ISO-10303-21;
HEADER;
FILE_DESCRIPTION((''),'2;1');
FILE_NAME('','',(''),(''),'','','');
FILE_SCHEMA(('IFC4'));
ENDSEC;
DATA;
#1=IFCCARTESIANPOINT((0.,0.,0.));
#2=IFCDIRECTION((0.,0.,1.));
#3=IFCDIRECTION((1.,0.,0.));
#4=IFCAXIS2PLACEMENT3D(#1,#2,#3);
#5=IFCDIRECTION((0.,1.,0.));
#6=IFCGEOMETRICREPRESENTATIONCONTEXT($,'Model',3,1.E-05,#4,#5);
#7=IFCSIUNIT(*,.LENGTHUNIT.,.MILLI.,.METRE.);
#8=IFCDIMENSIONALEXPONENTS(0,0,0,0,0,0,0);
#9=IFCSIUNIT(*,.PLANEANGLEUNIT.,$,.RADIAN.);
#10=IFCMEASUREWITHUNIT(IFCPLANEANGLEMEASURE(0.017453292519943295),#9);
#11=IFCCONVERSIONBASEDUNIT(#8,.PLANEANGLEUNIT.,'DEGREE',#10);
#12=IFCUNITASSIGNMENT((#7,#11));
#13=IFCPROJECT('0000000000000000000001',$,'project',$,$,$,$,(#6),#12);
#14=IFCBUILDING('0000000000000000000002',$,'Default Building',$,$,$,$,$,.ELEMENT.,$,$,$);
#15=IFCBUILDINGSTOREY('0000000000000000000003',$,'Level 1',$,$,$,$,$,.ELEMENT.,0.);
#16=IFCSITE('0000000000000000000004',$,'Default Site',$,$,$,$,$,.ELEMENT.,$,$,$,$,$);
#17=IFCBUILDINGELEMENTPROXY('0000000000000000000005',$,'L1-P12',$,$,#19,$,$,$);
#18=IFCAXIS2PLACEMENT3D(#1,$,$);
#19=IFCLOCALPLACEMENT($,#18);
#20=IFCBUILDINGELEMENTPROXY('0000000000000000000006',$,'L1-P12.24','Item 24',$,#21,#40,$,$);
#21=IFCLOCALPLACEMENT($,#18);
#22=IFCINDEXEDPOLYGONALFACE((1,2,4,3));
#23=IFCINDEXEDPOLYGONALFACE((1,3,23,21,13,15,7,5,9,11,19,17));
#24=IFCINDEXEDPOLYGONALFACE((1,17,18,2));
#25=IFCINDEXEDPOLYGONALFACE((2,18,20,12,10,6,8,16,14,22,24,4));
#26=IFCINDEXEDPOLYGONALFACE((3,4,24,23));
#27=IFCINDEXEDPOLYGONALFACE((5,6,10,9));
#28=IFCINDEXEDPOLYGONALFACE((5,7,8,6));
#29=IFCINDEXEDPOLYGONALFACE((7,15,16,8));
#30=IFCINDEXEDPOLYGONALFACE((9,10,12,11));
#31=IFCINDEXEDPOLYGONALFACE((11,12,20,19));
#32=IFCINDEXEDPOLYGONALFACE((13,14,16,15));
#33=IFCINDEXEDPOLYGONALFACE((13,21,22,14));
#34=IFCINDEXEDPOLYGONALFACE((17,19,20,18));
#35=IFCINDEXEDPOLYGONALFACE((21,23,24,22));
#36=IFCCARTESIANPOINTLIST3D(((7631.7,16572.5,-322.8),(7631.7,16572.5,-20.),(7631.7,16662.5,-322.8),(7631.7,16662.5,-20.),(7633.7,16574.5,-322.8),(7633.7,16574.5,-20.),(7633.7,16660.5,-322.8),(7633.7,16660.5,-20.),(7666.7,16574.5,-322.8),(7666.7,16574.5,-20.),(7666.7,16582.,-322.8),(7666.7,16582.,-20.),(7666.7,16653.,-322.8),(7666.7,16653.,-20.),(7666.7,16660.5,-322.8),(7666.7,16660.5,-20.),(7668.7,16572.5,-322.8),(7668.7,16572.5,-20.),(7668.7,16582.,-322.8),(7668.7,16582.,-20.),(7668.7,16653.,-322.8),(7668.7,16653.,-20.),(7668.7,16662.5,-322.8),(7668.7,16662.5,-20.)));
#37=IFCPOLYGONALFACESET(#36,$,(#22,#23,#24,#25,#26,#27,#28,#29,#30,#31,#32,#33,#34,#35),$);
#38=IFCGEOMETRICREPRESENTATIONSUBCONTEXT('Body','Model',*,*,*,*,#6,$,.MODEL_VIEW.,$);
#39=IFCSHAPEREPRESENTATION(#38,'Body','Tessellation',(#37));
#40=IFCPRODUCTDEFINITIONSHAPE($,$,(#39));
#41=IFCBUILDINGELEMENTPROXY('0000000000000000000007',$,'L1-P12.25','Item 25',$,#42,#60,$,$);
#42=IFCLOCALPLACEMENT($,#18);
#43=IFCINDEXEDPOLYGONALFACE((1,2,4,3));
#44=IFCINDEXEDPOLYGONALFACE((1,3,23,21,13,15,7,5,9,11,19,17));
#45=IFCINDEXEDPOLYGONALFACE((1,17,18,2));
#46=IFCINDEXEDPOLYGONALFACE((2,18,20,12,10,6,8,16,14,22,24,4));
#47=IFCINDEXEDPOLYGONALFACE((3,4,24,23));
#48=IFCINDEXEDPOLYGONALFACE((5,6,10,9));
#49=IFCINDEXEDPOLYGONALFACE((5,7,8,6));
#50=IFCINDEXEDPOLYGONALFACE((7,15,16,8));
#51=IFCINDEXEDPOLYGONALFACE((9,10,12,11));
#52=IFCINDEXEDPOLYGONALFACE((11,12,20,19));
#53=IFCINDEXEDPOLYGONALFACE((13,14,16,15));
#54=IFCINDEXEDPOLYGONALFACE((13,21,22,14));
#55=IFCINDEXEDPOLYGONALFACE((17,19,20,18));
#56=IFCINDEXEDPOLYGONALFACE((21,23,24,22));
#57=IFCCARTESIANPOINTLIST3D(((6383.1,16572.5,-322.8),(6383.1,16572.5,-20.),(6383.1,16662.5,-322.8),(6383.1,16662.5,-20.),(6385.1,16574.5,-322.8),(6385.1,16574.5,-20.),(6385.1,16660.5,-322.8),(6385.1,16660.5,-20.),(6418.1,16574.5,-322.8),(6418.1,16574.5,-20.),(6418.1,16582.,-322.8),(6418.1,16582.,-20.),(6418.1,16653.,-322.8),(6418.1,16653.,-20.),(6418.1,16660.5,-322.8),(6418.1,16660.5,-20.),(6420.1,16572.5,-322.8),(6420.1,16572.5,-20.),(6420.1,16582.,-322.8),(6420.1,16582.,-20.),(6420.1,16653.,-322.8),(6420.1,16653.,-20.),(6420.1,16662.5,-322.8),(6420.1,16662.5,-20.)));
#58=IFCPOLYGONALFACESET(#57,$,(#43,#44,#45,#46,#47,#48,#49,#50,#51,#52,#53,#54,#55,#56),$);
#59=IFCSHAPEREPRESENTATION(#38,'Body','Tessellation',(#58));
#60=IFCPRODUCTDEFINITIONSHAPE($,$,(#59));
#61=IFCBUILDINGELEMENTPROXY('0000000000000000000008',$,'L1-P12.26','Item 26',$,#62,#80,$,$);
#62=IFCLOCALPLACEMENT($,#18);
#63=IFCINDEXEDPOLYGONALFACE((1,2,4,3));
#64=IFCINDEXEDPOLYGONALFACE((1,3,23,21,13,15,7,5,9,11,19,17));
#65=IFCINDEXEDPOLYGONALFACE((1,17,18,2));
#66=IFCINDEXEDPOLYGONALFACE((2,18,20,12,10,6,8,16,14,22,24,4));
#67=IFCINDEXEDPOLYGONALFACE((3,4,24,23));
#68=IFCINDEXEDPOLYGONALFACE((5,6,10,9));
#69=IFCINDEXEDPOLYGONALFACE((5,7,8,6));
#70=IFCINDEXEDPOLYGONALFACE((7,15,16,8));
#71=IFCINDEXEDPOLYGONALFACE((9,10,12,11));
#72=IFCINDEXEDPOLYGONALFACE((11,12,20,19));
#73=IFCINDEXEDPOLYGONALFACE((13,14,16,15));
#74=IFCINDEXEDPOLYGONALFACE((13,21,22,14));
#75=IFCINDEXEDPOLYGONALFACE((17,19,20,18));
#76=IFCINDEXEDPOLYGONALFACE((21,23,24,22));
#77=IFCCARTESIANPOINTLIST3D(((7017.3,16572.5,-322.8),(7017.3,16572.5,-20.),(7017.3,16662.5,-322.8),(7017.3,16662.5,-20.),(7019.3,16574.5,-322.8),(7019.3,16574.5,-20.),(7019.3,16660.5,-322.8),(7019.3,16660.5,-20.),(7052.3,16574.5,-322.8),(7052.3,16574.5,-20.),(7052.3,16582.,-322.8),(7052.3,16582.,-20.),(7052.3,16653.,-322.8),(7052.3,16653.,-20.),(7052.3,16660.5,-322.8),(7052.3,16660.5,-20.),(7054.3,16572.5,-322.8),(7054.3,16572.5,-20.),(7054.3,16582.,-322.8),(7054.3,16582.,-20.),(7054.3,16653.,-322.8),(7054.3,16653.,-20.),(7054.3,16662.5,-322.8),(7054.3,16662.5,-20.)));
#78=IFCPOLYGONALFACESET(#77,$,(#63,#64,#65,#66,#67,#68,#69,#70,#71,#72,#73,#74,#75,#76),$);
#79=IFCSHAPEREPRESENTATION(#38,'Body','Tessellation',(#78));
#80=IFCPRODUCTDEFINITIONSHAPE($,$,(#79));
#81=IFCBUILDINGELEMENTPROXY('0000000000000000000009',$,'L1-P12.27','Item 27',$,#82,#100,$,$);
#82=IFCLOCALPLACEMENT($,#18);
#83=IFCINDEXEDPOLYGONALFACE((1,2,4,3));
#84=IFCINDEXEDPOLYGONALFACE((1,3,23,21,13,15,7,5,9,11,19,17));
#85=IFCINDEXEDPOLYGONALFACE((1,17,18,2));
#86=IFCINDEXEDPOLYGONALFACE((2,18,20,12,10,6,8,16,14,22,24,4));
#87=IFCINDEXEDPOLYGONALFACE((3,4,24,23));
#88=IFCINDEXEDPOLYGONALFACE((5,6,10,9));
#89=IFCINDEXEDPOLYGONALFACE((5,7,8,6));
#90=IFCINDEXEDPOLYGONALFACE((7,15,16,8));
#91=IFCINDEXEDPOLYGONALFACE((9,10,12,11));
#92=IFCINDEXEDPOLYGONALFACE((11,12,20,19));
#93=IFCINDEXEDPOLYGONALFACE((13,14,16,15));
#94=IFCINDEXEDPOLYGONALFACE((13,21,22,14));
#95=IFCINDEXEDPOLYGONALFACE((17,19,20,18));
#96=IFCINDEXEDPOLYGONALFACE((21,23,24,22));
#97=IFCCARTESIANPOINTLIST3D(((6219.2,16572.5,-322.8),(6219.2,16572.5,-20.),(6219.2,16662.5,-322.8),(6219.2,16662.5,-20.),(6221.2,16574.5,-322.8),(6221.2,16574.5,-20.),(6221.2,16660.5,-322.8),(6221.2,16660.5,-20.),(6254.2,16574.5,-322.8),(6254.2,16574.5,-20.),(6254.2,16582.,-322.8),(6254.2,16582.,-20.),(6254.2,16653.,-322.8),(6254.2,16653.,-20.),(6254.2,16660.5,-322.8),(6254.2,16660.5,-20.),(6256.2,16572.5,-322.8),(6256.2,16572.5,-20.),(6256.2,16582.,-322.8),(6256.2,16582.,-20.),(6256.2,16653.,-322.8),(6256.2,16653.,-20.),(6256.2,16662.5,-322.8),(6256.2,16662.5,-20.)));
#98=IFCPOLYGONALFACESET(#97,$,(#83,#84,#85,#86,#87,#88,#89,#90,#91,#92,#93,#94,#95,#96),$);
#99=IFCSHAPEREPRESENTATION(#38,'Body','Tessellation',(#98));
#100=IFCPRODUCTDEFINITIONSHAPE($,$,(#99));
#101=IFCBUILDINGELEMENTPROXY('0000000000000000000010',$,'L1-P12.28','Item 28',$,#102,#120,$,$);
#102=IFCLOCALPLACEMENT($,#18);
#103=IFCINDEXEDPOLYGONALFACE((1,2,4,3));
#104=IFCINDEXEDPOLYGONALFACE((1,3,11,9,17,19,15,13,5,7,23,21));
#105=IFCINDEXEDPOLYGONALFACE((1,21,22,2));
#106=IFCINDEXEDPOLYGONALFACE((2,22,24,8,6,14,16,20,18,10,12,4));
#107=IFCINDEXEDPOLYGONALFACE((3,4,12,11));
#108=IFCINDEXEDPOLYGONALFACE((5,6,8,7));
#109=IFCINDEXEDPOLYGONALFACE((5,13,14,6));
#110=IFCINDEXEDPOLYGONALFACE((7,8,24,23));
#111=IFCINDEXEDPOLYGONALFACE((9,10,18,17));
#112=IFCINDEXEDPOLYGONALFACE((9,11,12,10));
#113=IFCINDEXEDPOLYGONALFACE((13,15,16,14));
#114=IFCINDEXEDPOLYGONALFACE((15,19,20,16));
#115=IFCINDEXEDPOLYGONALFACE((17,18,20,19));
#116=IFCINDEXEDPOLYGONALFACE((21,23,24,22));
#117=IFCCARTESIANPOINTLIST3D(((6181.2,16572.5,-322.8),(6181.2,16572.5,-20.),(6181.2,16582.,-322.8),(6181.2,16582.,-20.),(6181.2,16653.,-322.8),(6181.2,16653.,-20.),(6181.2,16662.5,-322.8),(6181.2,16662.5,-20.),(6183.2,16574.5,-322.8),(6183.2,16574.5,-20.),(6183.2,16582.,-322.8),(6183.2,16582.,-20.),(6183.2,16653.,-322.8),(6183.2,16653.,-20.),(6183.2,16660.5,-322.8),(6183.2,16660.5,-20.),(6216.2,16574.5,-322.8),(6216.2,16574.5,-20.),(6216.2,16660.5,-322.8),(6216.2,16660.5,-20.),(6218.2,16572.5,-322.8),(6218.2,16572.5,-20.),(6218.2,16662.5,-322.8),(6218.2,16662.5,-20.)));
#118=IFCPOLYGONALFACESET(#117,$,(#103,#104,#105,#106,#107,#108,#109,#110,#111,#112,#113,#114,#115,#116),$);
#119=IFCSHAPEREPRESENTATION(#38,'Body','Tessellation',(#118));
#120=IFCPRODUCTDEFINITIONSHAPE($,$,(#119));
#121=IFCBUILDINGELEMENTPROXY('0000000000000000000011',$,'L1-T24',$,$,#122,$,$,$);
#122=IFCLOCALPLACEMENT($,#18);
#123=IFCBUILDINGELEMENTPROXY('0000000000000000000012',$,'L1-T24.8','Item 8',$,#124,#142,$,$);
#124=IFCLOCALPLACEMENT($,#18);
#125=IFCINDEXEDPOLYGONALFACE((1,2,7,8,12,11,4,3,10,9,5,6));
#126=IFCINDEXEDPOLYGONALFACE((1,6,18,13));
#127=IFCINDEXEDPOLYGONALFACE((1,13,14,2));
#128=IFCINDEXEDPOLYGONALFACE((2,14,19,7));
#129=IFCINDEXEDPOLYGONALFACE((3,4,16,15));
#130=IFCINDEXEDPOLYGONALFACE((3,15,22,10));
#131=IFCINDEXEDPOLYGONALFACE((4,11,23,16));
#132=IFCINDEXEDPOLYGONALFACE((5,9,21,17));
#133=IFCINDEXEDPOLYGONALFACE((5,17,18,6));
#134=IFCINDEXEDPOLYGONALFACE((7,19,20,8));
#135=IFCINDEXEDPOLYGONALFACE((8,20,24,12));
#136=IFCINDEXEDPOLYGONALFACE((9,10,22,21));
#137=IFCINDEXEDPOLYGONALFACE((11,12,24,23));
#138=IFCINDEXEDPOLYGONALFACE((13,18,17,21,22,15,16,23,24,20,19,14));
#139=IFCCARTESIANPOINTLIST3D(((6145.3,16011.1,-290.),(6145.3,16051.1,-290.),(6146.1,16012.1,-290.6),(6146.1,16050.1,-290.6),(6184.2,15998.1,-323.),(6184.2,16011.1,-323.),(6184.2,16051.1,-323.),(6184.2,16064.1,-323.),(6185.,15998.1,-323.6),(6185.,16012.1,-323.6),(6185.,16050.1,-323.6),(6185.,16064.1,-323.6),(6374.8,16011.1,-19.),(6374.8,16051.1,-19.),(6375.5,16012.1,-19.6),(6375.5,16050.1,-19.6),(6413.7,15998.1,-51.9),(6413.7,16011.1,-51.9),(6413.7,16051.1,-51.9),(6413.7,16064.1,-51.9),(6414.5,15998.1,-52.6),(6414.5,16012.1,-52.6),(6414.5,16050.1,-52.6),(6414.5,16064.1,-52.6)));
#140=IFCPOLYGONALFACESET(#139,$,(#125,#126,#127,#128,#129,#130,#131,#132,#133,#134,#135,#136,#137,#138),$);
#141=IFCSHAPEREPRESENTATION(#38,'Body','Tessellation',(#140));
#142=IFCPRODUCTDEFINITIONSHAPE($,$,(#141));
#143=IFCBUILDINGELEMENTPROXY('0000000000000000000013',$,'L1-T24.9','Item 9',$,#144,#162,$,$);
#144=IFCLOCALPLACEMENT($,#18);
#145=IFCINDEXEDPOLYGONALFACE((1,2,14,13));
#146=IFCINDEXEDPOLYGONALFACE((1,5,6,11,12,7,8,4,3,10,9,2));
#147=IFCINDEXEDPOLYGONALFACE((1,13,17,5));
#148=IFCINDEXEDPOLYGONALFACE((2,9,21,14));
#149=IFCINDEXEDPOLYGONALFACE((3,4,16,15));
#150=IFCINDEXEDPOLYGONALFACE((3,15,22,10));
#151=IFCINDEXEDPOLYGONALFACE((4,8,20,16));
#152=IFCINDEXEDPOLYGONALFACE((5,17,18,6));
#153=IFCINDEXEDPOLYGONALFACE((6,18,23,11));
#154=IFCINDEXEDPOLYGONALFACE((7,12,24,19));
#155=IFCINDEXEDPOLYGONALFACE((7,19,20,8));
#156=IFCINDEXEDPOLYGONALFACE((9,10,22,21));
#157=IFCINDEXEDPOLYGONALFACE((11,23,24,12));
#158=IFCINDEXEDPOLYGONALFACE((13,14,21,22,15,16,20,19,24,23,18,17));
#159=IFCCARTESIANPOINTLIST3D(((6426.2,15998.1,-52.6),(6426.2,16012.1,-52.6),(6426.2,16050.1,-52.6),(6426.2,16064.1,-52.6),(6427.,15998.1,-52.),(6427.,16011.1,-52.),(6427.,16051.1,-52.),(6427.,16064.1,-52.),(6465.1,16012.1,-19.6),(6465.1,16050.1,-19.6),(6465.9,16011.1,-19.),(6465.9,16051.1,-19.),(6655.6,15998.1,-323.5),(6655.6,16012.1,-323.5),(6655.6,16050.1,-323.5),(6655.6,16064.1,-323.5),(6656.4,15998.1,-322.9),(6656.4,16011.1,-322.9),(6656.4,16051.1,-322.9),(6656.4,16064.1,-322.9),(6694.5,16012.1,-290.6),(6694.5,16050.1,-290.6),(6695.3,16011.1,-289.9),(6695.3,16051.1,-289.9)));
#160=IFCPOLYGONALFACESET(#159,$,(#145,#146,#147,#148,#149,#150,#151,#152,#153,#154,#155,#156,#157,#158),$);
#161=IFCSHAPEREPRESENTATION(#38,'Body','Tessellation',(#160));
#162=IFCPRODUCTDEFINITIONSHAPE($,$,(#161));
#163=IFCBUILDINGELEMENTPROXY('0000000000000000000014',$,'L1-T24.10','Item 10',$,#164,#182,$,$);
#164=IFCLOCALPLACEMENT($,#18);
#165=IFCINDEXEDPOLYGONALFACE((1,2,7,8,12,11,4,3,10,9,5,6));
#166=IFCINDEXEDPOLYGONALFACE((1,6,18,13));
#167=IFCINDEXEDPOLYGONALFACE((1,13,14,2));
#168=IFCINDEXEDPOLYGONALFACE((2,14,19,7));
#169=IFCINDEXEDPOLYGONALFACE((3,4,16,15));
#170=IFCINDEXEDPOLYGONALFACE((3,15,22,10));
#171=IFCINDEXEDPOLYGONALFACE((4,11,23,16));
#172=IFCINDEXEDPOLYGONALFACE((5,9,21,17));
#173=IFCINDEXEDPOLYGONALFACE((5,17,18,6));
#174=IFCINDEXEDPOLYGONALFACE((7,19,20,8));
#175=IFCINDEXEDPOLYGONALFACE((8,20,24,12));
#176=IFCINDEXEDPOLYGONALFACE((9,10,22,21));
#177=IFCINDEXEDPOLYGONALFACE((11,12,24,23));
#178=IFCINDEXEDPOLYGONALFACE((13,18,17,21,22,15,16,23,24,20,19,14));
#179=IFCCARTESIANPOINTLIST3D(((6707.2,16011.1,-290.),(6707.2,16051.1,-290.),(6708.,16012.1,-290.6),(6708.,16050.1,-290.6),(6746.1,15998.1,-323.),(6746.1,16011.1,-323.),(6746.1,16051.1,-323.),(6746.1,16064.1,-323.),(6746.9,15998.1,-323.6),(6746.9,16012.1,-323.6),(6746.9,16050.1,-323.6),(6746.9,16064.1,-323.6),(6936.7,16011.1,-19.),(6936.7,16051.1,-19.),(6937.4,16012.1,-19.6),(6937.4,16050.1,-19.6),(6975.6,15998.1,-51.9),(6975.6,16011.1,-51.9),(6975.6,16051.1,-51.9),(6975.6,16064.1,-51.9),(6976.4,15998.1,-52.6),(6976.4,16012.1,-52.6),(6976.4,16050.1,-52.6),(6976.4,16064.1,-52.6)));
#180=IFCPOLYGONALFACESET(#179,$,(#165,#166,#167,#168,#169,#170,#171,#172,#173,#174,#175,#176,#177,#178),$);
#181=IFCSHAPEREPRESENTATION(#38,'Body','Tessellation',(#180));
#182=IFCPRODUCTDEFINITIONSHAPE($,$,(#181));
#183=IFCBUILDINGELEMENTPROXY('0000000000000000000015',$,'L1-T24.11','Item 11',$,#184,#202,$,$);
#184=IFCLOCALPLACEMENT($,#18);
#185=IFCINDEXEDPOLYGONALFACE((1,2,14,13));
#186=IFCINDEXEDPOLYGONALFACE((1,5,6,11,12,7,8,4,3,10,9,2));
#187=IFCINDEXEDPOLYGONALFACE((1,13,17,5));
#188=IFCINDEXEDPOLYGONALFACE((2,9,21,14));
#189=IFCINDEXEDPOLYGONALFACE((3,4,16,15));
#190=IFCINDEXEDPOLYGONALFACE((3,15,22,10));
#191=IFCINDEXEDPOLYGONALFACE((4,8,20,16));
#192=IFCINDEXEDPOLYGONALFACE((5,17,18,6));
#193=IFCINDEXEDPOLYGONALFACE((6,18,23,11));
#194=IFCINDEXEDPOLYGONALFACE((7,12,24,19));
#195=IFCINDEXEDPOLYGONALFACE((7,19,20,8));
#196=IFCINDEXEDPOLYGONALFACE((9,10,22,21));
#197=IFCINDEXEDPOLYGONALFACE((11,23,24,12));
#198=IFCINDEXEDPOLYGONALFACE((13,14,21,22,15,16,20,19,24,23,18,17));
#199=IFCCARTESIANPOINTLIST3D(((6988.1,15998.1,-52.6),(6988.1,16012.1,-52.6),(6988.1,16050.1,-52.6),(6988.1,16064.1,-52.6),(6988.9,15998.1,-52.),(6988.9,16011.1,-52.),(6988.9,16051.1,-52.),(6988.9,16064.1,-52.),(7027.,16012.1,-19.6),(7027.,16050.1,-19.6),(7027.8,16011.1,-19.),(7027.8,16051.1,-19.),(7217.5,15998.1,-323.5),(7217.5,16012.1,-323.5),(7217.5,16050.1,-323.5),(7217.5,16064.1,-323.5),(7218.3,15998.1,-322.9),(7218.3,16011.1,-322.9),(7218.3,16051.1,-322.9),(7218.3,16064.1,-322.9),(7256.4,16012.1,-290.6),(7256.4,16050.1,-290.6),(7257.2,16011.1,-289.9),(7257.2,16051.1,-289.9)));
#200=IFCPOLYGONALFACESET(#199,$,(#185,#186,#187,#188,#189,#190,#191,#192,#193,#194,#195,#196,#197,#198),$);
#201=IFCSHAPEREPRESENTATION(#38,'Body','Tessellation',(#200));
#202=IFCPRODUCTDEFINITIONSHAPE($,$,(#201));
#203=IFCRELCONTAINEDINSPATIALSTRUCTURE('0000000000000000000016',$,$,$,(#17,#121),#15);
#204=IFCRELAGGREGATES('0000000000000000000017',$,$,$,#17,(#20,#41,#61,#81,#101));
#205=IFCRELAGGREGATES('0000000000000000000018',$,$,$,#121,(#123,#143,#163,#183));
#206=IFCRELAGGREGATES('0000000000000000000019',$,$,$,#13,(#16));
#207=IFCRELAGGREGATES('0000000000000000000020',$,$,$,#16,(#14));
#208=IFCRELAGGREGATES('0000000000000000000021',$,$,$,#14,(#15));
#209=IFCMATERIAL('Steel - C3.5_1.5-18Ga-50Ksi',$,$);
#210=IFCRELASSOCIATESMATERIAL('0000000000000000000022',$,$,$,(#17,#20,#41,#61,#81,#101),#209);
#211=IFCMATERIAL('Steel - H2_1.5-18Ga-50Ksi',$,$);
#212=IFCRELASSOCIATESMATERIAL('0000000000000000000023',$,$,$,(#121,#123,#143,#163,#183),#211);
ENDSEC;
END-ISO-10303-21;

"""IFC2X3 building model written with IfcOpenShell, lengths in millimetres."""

from ifc_helpers import new_model, entity, si_unit, converted_unit, direction, frame, origin, origin_with_axes, origin_2d_with_axis, place, context, subcontext, project, spatial, polyline, c_section, outline, extrude, material, element, aggregate, save


model = new_model("IFC2X3")

# Units and contexts
model_context = context("Model", 3, precision=1e-05, world=origin_with_axes(), true_north=direction((0.0, 1.0, 0.0)))
body_context = subcontext(model_context, "Body", "Model", "MODEL_VIEW")
ifc_project = project(units=[si_unit("LENGTHUNIT", "METRE", prefix="MILLI"), converted_unit("PLANEANGLEUNIT", "DEGREE", entity("IfcPlaneAngleMeasure", 0.017453292519943295), si_unit("PLANEANGLEUNIT", "RADIAN"), dimensions=[0, 0, 0, 0, 0, 0, 0])], contexts=[model_context])

# Site, building, storey
site = spatial("IfcSite", under=ifc_project, Name="Default Site", CompositionType="ELEMENT")
building = spatial("IfcBuilding", under=site, Name="Default Building", CompositionType="ELEMENT")
storey = spatial("IfcBuildingStorey", under=building, Name="Level 1", CompositionType="ELEMENT", Elevation=0.0)

# Building element proxies
ifc_material_1 = material(Name="Steel - C3.5_1.5-18Ga-50Ksi")
proxy_1 = element("IfcBuildingElementProxy", 1, inside=storey, material=ifc_material_1, Name="L1-P12")
proxy_2_placement = place(None, frame((7650.2, 16617.5, -322.8), z_axis=(0.0, 0.0, 1.0), x_axis=(37.0, 0.0, 0.0)))
proxy_2 = element("IfcBuildingElementProxy", 2, at=proxy_2_placement, material=ifc_material_1, Name="L1-P12.24", Description="Item 24", context=body_context, shape_type="SweptSolid", body=[
    extrude(c_section(Depth=90.0, Width=37.0, WallThickness=2.0, Girth=9.5, at=origin_2d_with_axis()), origin(), (0.0, 0.0, 1.0), 302.8),
])
proxy_3_placement = place(None, frame((6401.6, 16617.5, -322.8), z_axis=(0.0, 0.0, 1.0), x_axis=(37.0, 0.0, 0.0)))
proxy_3 = element("IfcBuildingElementProxy", 3, at=proxy_3_placement, material=ifc_material_1, Name="L1-P12.25", Description="Item 25", context=body_context, shape_type="SweptSolid", body=[
    extrude(c_section(Depth=90.0, Width=37.0, WallThickness=2.0, Girth=9.5, at=origin_2d_with_axis()), origin(), (0.0, 0.0, 1.0), 302.8),
])
proxy_4_placement = place(None, frame((7035.8, 16617.5, -322.8), z_axis=(0.0, 0.0, 1.0), x_axis=(37.0, 0.0, 0.0)))
proxy_4 = element("IfcBuildingElementProxy", 4, at=proxy_4_placement, material=ifc_material_1, Name="L1-P12.26", Description="Item 26", context=body_context, shape_type="SweptSolid", body=[
    extrude(c_section(Depth=90.0, Width=37.0, WallThickness=2.0, Girth=9.5, at=origin_2d_with_axis()), origin(), (0.0, 0.0, 1.0), 302.8),
])
proxy_5_placement = place(None, frame((6237.7, 16617.5, -322.8), z_axis=(0.0, 0.0, 1.0), x_axis=(37.0, 0.0, 0.0)))
proxy_5 = element("IfcBuildingElementProxy", 5, at=proxy_5_placement, material=ifc_material_1, Name="L1-P12.27", Description="Item 27", context=body_context, shape_type="SweptSolid", body=[
    extrude(c_section(Depth=90.0, Width=37.0, WallThickness=2.0, Girth=9.5, at=origin_2d_with_axis()), origin(), (0.0, 0.0, 1.0), 302.8),
])
proxy_6_placement = place(None, frame((6199.7, 16617.5, -20.0), z_axis=(0.0, 0.0, -1.0), x_axis=(-37.0, 0.0, 0.0)))
proxy_6 = element("IfcBuildingElementProxy", 6, at=proxy_6_placement, material=ifc_material_1, Name="L1-P12.28", Description="Item 28", context=body_context, shape_type="SweptSolid", body=[
    extrude(c_section(Depth=90.0, Width=37.0, WallThickness=2.0, Girth=9.5, at=origin_2d_with_axis()), origin(), (0.0, 0.0, 1.0), 302.8),
])
aggregate(proxy_1, [proxy_2, proxy_3, proxy_4, proxy_5, proxy_6])
ifc_material_2 = material(Name="Steel - H2_1.5-18Ga-50Ksi")
proxy_7 = element("IfcBuildingElementProxy", 7, inside=storey, material=ifc_material_2, Name="L1-T24")
proxy_8_placement = place(None, frame((6185.0, 15998.1, -323.6), z_axis=(0.646, 0.0, 0.763), x_axis=(0.0, 40.0, 0.0)))
proxy_8 = element("IfcBuildingElementProxy", 8, at=proxy_8_placement, material=ifc_material_2, Name="L1-T24.8", Description="Item 8", context=body_context, shape_type="SweptSolid", body=[
    extrude(outline(polyline([(0.0, 0.0), (14.0, 0.0), (14.0, 51.0), (52.0, 51.0), (52.0, 0.0), (66.0, 0.0), (66.0, 1.0), (53.0, 1.0), (53.0, 52.0), (13.0, 52.0), (13.0, 1.0), (0.0, 1.0), (0.0, 0.0)])), origin(), (0.0, 0.0, 1.0), 355.1),
])
proxy_9_placement = place(None, frame((6426.2, 15998.1, -52.6), z_axis=(0.646, 0.0, -0.763), x_axis=(0.0, 40.0, 0.0)))
proxy_9 = element("IfcBuildingElementProxy", 9, at=proxy_9_placement, material=ifc_material_2, Name="L1-T24.9", Description="Item 9", context=body_context, shape_type="SweptSolid", body=[
    extrude(outline(polyline([(0.0, 0.0), (14.0, 0.0), (14.0, 51.0), (52.0, 51.0), (52.0, 0.0), (66.0, 0.0), (66.0, 1.0), (53.0, 1.0), (53.0, 52.0), (13.0, 52.0), (13.0, 1.0), (0.0, 1.0), (0.0, 0.0)])), origin(), (0.0, 0.0, 1.0), 355.0),
])
proxy_10_placement = place(None, frame((6746.9, 15998.1, -323.6), z_axis=(0.646, 0.0, 0.763), x_axis=(0.0, 40.0, 0.0)))
proxy_10 = element("IfcBuildingElementProxy", 10, at=proxy_10_placement, material=ifc_material_2, Name="L1-T24.10", Description="Item 10", context=body_context, shape_type="SweptSolid", body=[
    extrude(outline(polyline([(0.0, 0.0), (14.0, 0.0), (14.0, 51.0), (52.0, 51.0), (52.0, 0.0), (66.0, 0.0), (66.0, 1.0), (53.0, 1.0), (53.0, 52.0), (13.0, 52.0), (13.0, 1.0), (0.0, 1.0), (0.0, 0.0)])), origin(), (0.0, 0.0, 1.0), 355.1),
])
proxy_11_placement = place(None, frame((6988.1, 15998.1, -52.6), z_axis=(0.646, 0.0, -0.763), x_axis=(0.0, 40.0, 0.0)))
proxy_11 = element("IfcBuildingElementProxy", 11, at=proxy_11_placement, material=ifc_material_2, Name="L1-T24.11", Description="Item 11", context=body_context, shape_type="SweptSolid", body=[
    extrude(outline(polyline([(0.0, 0.0), (14.0, 0.0), (14.0, 51.0), (52.0, 51.0), (52.0, 0.0), (66.0, 0.0), (66.0, 1.0), (53.0, 1.0), (53.0, 52.0), (13.0, 52.0), (13.0, 1.0), (0.0, 1.0), (0.0, 0.0)])), origin(), (0.0, 0.0, 1.0), 355.0),
])
aggregate(proxy_7, [proxy_8, proxy_9, proxy_10, proxy_11])

save(model, "model.ifc")
